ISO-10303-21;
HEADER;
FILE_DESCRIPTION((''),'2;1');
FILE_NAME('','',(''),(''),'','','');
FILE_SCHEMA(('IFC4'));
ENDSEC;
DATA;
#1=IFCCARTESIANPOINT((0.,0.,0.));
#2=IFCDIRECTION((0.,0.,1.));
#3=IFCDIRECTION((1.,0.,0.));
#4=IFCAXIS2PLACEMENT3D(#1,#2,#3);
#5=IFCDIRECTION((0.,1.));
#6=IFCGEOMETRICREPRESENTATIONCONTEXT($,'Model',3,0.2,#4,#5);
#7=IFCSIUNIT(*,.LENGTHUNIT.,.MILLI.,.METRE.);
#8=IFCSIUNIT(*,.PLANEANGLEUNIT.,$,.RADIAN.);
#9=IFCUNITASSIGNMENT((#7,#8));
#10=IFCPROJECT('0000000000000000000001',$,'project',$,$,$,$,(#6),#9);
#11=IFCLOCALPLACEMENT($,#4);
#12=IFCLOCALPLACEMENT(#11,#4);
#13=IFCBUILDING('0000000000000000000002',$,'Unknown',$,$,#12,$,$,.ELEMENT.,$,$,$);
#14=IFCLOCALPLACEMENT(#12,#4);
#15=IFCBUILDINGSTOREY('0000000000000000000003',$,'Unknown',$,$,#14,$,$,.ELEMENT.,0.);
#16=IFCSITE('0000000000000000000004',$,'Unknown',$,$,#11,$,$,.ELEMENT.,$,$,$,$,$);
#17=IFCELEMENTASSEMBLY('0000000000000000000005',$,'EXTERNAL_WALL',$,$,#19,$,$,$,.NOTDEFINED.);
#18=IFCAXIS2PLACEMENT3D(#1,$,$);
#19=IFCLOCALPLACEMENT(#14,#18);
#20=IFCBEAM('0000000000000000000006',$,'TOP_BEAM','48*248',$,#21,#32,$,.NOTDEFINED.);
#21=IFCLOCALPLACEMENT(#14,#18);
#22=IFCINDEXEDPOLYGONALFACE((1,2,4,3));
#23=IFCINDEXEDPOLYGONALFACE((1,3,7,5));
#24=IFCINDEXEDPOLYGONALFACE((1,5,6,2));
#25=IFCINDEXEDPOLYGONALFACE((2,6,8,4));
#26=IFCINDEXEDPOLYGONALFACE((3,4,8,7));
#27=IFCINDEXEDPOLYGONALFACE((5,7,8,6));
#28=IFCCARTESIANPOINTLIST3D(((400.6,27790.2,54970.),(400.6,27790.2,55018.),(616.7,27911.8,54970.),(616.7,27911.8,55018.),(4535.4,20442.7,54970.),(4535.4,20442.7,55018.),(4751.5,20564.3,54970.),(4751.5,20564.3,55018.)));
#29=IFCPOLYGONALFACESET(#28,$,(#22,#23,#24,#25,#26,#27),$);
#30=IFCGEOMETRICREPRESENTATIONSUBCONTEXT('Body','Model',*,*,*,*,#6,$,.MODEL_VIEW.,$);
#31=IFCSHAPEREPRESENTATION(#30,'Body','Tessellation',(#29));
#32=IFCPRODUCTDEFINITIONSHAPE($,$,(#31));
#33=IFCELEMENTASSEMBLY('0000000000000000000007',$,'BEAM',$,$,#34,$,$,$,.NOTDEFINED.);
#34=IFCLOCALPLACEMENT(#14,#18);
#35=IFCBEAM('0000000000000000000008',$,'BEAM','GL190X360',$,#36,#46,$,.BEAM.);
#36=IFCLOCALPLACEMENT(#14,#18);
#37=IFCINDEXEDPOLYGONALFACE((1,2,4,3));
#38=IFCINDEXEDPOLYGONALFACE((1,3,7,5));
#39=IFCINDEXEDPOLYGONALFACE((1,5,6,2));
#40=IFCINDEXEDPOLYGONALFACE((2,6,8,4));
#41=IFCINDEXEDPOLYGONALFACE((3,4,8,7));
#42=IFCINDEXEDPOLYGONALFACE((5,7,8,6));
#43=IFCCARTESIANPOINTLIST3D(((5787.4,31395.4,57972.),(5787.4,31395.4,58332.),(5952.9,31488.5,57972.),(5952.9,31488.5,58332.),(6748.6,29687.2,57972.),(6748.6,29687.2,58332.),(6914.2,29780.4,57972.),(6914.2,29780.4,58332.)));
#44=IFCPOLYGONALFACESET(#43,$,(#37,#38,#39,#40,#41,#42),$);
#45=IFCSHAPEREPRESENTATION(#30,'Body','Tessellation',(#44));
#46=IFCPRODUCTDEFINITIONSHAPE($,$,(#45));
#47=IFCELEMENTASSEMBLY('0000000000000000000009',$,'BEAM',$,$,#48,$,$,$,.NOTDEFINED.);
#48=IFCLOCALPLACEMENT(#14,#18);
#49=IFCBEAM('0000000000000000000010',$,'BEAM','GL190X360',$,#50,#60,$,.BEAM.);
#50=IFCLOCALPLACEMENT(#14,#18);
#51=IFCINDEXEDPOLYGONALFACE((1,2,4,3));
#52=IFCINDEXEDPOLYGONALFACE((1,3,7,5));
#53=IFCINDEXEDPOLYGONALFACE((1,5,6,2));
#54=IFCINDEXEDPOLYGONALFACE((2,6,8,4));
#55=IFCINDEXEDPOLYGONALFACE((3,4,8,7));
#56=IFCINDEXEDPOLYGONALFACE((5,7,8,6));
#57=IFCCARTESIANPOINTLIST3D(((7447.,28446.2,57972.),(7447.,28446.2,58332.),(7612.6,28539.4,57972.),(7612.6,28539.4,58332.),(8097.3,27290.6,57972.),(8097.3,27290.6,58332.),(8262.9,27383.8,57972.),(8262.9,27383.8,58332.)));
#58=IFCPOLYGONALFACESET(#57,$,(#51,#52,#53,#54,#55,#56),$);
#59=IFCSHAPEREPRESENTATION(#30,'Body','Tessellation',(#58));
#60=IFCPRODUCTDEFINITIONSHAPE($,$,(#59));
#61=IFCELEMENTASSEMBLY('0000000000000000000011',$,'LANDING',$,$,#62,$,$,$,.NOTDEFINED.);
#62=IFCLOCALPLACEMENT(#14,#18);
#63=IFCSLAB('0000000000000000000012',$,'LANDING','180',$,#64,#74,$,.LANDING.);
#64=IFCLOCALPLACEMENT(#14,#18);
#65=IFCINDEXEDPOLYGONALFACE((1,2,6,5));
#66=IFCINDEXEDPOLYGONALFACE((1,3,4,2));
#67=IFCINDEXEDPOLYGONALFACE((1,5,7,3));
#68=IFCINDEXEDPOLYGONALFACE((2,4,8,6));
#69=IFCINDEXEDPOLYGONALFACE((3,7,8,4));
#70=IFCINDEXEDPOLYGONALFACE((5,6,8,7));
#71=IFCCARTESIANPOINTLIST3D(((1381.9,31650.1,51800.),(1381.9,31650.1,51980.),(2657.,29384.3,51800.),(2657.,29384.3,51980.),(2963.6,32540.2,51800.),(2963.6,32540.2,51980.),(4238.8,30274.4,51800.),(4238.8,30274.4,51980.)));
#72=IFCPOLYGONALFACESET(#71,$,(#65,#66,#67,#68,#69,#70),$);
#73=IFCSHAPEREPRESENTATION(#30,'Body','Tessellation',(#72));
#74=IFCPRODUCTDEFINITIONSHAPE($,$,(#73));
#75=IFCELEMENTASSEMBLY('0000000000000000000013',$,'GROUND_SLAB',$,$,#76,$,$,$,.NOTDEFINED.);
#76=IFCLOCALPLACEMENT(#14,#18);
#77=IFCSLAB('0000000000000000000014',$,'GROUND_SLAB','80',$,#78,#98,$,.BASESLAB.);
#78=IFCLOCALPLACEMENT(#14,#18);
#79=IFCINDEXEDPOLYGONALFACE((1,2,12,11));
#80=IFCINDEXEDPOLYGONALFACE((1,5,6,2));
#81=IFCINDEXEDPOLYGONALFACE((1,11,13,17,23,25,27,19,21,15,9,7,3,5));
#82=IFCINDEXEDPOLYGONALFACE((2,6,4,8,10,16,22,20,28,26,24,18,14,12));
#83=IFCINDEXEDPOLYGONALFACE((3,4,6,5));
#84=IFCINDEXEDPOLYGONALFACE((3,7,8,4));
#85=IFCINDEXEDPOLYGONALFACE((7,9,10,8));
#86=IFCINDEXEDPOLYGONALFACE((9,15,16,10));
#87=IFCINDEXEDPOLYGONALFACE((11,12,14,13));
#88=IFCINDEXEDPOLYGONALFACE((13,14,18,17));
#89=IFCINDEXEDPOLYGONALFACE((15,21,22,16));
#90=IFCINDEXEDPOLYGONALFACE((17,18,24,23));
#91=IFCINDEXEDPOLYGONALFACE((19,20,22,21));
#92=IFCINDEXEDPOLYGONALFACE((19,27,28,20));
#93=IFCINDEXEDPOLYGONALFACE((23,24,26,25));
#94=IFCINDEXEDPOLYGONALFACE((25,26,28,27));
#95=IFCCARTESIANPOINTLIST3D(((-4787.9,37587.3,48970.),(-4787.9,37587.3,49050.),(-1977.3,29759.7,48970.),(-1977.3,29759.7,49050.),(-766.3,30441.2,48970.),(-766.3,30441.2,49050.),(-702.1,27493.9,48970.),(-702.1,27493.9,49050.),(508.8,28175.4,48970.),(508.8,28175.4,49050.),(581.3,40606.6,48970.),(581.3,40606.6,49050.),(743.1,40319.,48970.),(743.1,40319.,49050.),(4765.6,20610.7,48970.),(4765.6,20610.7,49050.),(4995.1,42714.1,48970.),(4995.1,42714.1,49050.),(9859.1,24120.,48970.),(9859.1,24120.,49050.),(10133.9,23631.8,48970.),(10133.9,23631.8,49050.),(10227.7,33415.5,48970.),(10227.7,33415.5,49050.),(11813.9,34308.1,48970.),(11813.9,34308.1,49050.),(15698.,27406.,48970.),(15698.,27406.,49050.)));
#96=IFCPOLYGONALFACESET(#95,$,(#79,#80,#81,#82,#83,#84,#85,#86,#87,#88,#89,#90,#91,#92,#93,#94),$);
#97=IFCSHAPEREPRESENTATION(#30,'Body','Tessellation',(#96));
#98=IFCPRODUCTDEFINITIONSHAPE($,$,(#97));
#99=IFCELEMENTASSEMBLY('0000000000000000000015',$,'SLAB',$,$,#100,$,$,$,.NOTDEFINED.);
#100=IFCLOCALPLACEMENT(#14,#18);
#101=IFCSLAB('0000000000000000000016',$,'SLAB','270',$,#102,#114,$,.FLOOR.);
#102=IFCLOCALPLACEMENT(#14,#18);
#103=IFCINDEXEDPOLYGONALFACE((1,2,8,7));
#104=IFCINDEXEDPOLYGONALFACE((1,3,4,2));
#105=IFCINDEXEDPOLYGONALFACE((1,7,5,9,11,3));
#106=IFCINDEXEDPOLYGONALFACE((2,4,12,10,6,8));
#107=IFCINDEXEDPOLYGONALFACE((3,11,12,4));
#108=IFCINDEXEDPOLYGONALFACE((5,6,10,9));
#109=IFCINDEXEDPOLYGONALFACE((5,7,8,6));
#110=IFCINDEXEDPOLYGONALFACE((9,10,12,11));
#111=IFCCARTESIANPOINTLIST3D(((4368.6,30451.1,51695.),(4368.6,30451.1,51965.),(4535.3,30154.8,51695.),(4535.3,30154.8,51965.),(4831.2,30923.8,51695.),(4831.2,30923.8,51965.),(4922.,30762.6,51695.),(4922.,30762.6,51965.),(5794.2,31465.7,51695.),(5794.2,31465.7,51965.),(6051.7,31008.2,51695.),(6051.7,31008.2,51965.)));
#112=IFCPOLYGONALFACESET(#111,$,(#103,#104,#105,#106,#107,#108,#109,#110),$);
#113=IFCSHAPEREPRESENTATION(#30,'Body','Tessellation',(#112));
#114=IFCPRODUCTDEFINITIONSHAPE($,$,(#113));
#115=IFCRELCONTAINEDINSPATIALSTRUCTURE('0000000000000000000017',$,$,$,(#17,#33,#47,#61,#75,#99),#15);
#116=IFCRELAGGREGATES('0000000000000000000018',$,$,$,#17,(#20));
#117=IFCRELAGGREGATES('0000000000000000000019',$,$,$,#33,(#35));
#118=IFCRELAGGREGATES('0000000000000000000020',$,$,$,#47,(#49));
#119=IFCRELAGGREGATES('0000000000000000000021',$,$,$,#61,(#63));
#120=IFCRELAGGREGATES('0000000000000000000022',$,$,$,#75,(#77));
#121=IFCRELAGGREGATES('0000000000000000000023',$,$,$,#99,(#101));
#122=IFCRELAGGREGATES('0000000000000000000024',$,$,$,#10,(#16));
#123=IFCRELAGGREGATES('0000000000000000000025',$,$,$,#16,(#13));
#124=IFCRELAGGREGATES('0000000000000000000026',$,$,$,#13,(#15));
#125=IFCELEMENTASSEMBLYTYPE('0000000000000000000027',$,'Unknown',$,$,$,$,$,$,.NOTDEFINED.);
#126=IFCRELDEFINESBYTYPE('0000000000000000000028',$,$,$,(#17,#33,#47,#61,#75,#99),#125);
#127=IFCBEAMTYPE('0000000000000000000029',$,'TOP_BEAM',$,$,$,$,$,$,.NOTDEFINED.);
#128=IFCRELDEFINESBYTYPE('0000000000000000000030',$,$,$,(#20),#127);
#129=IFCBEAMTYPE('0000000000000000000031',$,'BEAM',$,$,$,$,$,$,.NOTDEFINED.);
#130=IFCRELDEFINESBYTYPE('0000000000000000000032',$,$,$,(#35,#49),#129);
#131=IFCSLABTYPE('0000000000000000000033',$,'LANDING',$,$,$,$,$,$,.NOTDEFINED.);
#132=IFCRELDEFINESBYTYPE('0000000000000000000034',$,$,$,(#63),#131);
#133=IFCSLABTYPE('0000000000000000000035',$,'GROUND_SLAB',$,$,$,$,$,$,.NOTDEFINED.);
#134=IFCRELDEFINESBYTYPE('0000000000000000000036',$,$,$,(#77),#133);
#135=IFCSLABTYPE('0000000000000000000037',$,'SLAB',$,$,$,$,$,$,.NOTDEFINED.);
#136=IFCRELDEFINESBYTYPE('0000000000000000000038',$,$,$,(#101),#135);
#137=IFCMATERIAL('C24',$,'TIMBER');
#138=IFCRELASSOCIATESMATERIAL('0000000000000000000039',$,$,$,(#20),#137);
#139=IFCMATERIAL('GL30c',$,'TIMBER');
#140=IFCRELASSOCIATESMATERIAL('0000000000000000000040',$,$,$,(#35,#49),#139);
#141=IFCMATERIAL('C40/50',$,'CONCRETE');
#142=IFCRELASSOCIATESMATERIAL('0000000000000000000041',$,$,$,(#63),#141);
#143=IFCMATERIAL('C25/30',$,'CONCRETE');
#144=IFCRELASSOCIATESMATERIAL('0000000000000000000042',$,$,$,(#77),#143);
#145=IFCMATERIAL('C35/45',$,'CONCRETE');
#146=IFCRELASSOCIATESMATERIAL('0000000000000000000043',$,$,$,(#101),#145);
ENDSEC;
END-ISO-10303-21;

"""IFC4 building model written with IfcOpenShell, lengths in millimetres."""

from ifc_helpers import new_model, si_unit, direction, frame, origin_with_axes, origin_2d_with_axis, place, context, subcontext, project, spatial, polyline, line, indexed_curve, rectangle, outline, extrude, material, material_profile, profile_set, profile_usage, type_object, element, aggregate, save


model = new_model("IFC4")

# Units and contexts
model_context = context("Model", 3, precision=0.2, world=origin_with_axes(), true_north=direction((0.0, 1.0)))
body_context = subcontext(model_context, "Body", "Model", "MODEL_VIEW")
ifc_project = project(units=[si_unit("LENGTHUNIT", "METRE", prefix="MILLI"), si_unit("PLANEANGLEUNIT", "RADIAN")], contexts=[model_context])

# Site, building, storey
site_placement = place(None, origin_with_axes())
site = spatial("IfcSite", under=ifc_project, at=site_placement, Name="Unknown", CompositionType="ELEMENT")
building_placement = place(site_placement, origin_with_axes())
building = spatial("IfcBuilding", under=site, at=building_placement, Name="Unknown", CompositionType="ELEMENT")
storey_placement = place(building_placement, origin_with_axes())
storey = spatial("IfcBuildingStorey", under=building, at=storey_placement, Name="Unknown", CompositionType="ELEMENT", Elevation=0.0)

# Shared definitions
element_assembly_type = type_object("IfcElementAssemblyType", Name="Unknown", PredefinedType="NOTDEFINED")
ifc_material_1 = material(Name="C40/50", Category="CONCRETE")

# Element assembly
ifc_material_2 = material(Name="C24", Category="TIMBER")
ifc_material_profile_1 = material_profile(ifc_material_2, rectangle(XDim=248.0, YDim=48.0, at=origin_2d_with_axis()), Name="48*248")
ifc_profile_set_1 = profile_set([ifc_material_profile_1])
ifc_profile_usage_1 = profile_usage(ifc_profile_set_1, cardinal=3)
assembly_1_placement = place(storey_placement, frame((4643.5, 20503.5, 54994.0), z_axis=(0.871484, 0.490423, 0.0), x_axis=(-0.490421, 0.871486, 0.0)))
assembly_1 = element("IfcElementAssembly", 1, at=assembly_1_placement, inside=storey, type_object=element_assembly_type, Name="EXTERNAL_WALL", PredefinedType="NOTDEFINED")

# Beam
beam_type_1 = type_object("IfcBeamType", Name="TOP_BEAM")
beam_1_placement = place(assembly_1_placement, origin_with_axes())
beam_1 = element("IfcBeam", 2, at=beam_1_placement, type_object=beam_type_1, material=ifc_profile_usage_1, Name="TOP_BEAM", Description="48*248", PredefinedType="NOTDEFINED", context=body_context, shape_type="SolidModel", body=[
    extrude(rectangle(XDim=248.0, YDim=48.0, at=origin_2d_with_axis()), frame((0.0, 0.0, 0.0), z_axis=(-1.0, 0.0, 0.0), x_axis=(0.0, 0.0, 1.0)), (0.0, 0.0, -1.0), 8431.0),
])
aggregate(assembly_1, [beam_1])

# Element assemblies, beams
assembly_2_placement = place(storey_placement, frame((5870.2, 31441.9, 58152.0), z_axis=(-0.871487, -0.490418, 0.0), x_axis=(0.490421, -0.871485, 0.0)))
assembly_2 = element("IfcElementAssembly", 3, at=assembly_2_placement, inside=storey, type_object=element_assembly_type, Name="BEAM", PredefinedType="NOTDEFINED")
ifc_material_3 = material(Name="GL30c", Category="TIMBER")
ifc_material_profile_2 = material_profile(ifc_material_3, outline(polyline([(-95.0, 180.0), (-95.0, -180.0), (95.0, -180.0), (95.0, 180.0), (-95.0, 180.0)])), Name="GL190X360")
ifc_profile_set_2 = profile_set([ifc_material_profile_2])
ifc_profile_usage_2 = profile_usage(ifc_profile_set_2, cardinal=8)
beam_type_2 = type_object("IfcBeamType", Name="BEAM")
beam_2_placement = place(assembly_2_placement, origin_with_axes())
beam_2 = element("IfcBeam", 4, at=beam_2_placement, type_object=beam_type_2, material=ifc_profile_usage_2, Name="BEAM", Description="GL190X360", PredefinedType="BEAM", context=body_context, shape_type="SolidModel", body=[
    extrude(outline(polyline([(-95.0, 180.0), (-95.0, -180.0), (95.0, -180.0), (95.0, 180.0), (-95.0, 180.0)])), frame((0.0, 0.0, 0.0), z_axis=(-1.0, 0.0, 0.0), x_axis=(0.0, 0.0, 1.0)), (0.0, 0.0, -1.0), 1960.0),
])
aggregate(assembly_2, [beam_2])
assembly_3_placement = place(storey_placement, frame((7529.8, 28492.8, 58152.0), z_axis=(-0.871487, -0.490418, 0.0), x_axis=(0.490421, -0.871485, 0.0)))
assembly_3 = element("IfcElementAssembly", 5, at=assembly_3_placement, inside=storey, type_object=element_assembly_type, Name="BEAM", PredefinedType="NOTDEFINED")
beam_3_placement = place(assembly_3_placement, origin_with_axes())
beam_3 = element("IfcBeam", 6, at=beam_3_placement, type_object=beam_type_2, material=ifc_profile_usage_2, Name="BEAM", Description="GL190X360", PredefinedType="BEAM", context=body_context, shape_type="SolidModel", body=[
    extrude(outline(polyline([(-95.0, 180.0), (-95.0, -180.0), (95.0, -180.0), (95.0, 180.0), (-95.0, 180.0)])), frame((0.0, 0.0, 0.0), z_axis=(-1.0, 0.0, 0.0), x_axis=(0.0, 0.0, 1.0)), (0.0, 0.0, -1.0), 1326.0),
])
aggregate(assembly_3, [beam_3])

# Element assemblies, slabs
assembly_4_placement = place(storey_placement, frame((4238.8, 30274.4, 51890.0), z_axis=(0.0, 0.0, 1.0), x_axis=(-0.490441, 0.871474, 0.0)))
assembly_4 = element("IfcElementAssembly", 7, at=assembly_4_placement, inside=storey, type_object=element_assembly_type, Name="LANDING", PredefinedType="NOTDEFINED")
ifc_material_profile_3 = material_profile(ifc_material_1, outline(indexed_curve([(0.0, 0.0), (2600.0, 0.0), (2600.0, 1814.9), (0.0, 1815.0)], segments=[line(1, 2, 3, 4, 1)])), Name="180")
ifc_profile_set_3 = profile_set([ifc_material_profile_3])
ifc_profile_usage_3 = profile_usage(ifc_profile_set_3, cardinal=8)
slab_type_1 = type_object("IfcSlabType", Name="LANDING")
slab_1_placement = place(assembly_4_placement, origin_with_axes())
slab_1 = element("IfcSlab", 8, at=slab_1_placement, type_object=slab_type_1, material=ifc_profile_usage_3, Name="LANDING", Description="180", PredefinedType="LANDING", context=body_context, shape_type="SolidModel", body=[
    extrude(outline(indexed_curve([(0.0, 0.0), (2600.0, 0.0), (2600.0, 1814.9), (0.0, 1815.0)], segments=[line(1, 2, 3, 4, 1)])), frame((0.0, 0.0, 90.0), z_axis=(0.0, 0.0, 1.0), x_axis=(1.0, 0.0, 0.0)), (0.0, 0.0, -1.0), 180.0),
])
aggregate(assembly_4, [slab_1])
assembly_5_placement = place(storey_placement, frame((15698.0, 27406.0, 49010.0), z_axis=(0.0, 0.0, 1.0), x_axis=(-0.490421, 0.871486, 0.0)))
assembly_5 = element("IfcElementAssembly", 9, at=assembly_5_placement, inside=storey, type_object=element_assembly_type, Name="GROUND_SLAB", PredefinedType="NOTDEFINED")
ifc_material_4 = material(Name="C25/30", Category="CONCRETE")
ifc_material_profile_4 = material_profile(ifc_material_4, outline(indexed_curve([(0.0, 0.0), (7920.0, 0.0), (7920.0, 1820.2), (18589.8, 1820.0), (18587.7, 6700.2), (18917.7, 6700.1), (18919.6, 12860.1), (10719.6, 12859.9), (10719.6, 14249.4), (8119.6, 14249.4), (8119.7, 12859.8), (-560.5, 12860.0), (-560.3, 6700.0), (-0.2, 6700.0)], segments=[line(1, 2, 3, 4, 5, 6, 7, 8, 9, 10, 11, 12, 13, 14, 1)])), Name="80")
ifc_profile_set_4 = profile_set([ifc_material_profile_4])
ifc_profile_usage_4 = profile_usage(ifc_profile_set_4, cardinal=8)
slab_type_2 = type_object("IfcSlabType", Name="GROUND_SLAB")
slab_2_placement = place(assembly_5_placement, origin_with_axes())
slab_2 = element("IfcSlab", 10, at=slab_2_placement, type_object=slab_type_2, material=ifc_profile_usage_4, Name="GROUND_SLAB", Description="80", PredefinedType="BASESLAB", context=body_context, shape_type="SolidModel", body=[
    extrude(outline(indexed_curve([(0.0, 0.0), (7920.0, 0.0), (7920.0, 1820.2), (18589.8, 1820.0), (18587.7, 6700.2), (18917.7, 6700.1), (18919.6, 12860.1), (10719.6, 12859.9), (10719.6, 14249.4), (8119.6, 14249.4), (8119.7, 12859.8), (-560.5, 12860.0), (-560.3, 6700.0), (-0.2, 6700.0)], segments=[line(1, 2, 3, 4, 5, 6, 7, 8, 9, 10, 11, 12, 13, 14, 1)])), frame((0.0, 0.0, 40.0), z_axis=(0.0, 0.0, 1.0), x_axis=(1.0, 0.0, 0.0)), (0.0, 0.0, -1.0), 80.0),
])
aggregate(assembly_5, [slab_2])
assembly_6_placement = place(storey_placement, frame((4831.2, 30923.8, 51830.0), z_axis=(0.0, 0.0, 1.0), x_axis=(0.490421, -0.871485, 0.0)))
assembly_6 = element("IfcElementAssembly", 11, at=assembly_6_placement, inside=storey, type_object=element_assembly_type, Name="SLAB", PredefinedType="NOTDEFINED")
ifc_material_5 = material(Name="C35/45", Category="CONCRETE")
ifc_material_profile_5 = material_profile(ifc_material_5, outline(indexed_curve([(0.0, 0.0), (185.0, 0.0), (185.1, -635.0), (525.1, -635.0), (525.0, 1105.0), (0.0, 1105.0)], segments=[line(1, 2, 3, 4, 5, 6, 1)])), Name="270")
ifc_profile_set_5 = profile_set([ifc_material_profile_5])
ifc_profile_usage_5 = profile_usage(ifc_profile_set_5, cardinal=8)
slab_type_3 = type_object("IfcSlabType", Name="SLAB")
slab_3_placement = place(assembly_6_placement, origin_with_axes())
slab_3 = element("IfcSlab", 12, at=slab_3_placement, type_object=slab_type_3, material=ifc_profile_usage_5, Name="SLAB", Description="270", PredefinedType="FLOOR", context=body_context, shape_type="SolidModel", body=[
    extrude(outline(indexed_curve([(0.0, 0.0), (185.0, 0.0), (185.1, -635.0), (525.1, -635.0), (525.0, 1105.0), (0.0, 1105.0)], segments=[line(1, 2, 3, 4, 5, 6, 1)])), frame((0.0, 0.0, 135.0), z_axis=(0.0, 0.0, 1.0), x_axis=(1.0, 0.0, 0.0)), (0.0, 0.0, -1.0), 270.0),
])
aggregate(assembly_6, [slab_3])

save(model, "model.ifc")
